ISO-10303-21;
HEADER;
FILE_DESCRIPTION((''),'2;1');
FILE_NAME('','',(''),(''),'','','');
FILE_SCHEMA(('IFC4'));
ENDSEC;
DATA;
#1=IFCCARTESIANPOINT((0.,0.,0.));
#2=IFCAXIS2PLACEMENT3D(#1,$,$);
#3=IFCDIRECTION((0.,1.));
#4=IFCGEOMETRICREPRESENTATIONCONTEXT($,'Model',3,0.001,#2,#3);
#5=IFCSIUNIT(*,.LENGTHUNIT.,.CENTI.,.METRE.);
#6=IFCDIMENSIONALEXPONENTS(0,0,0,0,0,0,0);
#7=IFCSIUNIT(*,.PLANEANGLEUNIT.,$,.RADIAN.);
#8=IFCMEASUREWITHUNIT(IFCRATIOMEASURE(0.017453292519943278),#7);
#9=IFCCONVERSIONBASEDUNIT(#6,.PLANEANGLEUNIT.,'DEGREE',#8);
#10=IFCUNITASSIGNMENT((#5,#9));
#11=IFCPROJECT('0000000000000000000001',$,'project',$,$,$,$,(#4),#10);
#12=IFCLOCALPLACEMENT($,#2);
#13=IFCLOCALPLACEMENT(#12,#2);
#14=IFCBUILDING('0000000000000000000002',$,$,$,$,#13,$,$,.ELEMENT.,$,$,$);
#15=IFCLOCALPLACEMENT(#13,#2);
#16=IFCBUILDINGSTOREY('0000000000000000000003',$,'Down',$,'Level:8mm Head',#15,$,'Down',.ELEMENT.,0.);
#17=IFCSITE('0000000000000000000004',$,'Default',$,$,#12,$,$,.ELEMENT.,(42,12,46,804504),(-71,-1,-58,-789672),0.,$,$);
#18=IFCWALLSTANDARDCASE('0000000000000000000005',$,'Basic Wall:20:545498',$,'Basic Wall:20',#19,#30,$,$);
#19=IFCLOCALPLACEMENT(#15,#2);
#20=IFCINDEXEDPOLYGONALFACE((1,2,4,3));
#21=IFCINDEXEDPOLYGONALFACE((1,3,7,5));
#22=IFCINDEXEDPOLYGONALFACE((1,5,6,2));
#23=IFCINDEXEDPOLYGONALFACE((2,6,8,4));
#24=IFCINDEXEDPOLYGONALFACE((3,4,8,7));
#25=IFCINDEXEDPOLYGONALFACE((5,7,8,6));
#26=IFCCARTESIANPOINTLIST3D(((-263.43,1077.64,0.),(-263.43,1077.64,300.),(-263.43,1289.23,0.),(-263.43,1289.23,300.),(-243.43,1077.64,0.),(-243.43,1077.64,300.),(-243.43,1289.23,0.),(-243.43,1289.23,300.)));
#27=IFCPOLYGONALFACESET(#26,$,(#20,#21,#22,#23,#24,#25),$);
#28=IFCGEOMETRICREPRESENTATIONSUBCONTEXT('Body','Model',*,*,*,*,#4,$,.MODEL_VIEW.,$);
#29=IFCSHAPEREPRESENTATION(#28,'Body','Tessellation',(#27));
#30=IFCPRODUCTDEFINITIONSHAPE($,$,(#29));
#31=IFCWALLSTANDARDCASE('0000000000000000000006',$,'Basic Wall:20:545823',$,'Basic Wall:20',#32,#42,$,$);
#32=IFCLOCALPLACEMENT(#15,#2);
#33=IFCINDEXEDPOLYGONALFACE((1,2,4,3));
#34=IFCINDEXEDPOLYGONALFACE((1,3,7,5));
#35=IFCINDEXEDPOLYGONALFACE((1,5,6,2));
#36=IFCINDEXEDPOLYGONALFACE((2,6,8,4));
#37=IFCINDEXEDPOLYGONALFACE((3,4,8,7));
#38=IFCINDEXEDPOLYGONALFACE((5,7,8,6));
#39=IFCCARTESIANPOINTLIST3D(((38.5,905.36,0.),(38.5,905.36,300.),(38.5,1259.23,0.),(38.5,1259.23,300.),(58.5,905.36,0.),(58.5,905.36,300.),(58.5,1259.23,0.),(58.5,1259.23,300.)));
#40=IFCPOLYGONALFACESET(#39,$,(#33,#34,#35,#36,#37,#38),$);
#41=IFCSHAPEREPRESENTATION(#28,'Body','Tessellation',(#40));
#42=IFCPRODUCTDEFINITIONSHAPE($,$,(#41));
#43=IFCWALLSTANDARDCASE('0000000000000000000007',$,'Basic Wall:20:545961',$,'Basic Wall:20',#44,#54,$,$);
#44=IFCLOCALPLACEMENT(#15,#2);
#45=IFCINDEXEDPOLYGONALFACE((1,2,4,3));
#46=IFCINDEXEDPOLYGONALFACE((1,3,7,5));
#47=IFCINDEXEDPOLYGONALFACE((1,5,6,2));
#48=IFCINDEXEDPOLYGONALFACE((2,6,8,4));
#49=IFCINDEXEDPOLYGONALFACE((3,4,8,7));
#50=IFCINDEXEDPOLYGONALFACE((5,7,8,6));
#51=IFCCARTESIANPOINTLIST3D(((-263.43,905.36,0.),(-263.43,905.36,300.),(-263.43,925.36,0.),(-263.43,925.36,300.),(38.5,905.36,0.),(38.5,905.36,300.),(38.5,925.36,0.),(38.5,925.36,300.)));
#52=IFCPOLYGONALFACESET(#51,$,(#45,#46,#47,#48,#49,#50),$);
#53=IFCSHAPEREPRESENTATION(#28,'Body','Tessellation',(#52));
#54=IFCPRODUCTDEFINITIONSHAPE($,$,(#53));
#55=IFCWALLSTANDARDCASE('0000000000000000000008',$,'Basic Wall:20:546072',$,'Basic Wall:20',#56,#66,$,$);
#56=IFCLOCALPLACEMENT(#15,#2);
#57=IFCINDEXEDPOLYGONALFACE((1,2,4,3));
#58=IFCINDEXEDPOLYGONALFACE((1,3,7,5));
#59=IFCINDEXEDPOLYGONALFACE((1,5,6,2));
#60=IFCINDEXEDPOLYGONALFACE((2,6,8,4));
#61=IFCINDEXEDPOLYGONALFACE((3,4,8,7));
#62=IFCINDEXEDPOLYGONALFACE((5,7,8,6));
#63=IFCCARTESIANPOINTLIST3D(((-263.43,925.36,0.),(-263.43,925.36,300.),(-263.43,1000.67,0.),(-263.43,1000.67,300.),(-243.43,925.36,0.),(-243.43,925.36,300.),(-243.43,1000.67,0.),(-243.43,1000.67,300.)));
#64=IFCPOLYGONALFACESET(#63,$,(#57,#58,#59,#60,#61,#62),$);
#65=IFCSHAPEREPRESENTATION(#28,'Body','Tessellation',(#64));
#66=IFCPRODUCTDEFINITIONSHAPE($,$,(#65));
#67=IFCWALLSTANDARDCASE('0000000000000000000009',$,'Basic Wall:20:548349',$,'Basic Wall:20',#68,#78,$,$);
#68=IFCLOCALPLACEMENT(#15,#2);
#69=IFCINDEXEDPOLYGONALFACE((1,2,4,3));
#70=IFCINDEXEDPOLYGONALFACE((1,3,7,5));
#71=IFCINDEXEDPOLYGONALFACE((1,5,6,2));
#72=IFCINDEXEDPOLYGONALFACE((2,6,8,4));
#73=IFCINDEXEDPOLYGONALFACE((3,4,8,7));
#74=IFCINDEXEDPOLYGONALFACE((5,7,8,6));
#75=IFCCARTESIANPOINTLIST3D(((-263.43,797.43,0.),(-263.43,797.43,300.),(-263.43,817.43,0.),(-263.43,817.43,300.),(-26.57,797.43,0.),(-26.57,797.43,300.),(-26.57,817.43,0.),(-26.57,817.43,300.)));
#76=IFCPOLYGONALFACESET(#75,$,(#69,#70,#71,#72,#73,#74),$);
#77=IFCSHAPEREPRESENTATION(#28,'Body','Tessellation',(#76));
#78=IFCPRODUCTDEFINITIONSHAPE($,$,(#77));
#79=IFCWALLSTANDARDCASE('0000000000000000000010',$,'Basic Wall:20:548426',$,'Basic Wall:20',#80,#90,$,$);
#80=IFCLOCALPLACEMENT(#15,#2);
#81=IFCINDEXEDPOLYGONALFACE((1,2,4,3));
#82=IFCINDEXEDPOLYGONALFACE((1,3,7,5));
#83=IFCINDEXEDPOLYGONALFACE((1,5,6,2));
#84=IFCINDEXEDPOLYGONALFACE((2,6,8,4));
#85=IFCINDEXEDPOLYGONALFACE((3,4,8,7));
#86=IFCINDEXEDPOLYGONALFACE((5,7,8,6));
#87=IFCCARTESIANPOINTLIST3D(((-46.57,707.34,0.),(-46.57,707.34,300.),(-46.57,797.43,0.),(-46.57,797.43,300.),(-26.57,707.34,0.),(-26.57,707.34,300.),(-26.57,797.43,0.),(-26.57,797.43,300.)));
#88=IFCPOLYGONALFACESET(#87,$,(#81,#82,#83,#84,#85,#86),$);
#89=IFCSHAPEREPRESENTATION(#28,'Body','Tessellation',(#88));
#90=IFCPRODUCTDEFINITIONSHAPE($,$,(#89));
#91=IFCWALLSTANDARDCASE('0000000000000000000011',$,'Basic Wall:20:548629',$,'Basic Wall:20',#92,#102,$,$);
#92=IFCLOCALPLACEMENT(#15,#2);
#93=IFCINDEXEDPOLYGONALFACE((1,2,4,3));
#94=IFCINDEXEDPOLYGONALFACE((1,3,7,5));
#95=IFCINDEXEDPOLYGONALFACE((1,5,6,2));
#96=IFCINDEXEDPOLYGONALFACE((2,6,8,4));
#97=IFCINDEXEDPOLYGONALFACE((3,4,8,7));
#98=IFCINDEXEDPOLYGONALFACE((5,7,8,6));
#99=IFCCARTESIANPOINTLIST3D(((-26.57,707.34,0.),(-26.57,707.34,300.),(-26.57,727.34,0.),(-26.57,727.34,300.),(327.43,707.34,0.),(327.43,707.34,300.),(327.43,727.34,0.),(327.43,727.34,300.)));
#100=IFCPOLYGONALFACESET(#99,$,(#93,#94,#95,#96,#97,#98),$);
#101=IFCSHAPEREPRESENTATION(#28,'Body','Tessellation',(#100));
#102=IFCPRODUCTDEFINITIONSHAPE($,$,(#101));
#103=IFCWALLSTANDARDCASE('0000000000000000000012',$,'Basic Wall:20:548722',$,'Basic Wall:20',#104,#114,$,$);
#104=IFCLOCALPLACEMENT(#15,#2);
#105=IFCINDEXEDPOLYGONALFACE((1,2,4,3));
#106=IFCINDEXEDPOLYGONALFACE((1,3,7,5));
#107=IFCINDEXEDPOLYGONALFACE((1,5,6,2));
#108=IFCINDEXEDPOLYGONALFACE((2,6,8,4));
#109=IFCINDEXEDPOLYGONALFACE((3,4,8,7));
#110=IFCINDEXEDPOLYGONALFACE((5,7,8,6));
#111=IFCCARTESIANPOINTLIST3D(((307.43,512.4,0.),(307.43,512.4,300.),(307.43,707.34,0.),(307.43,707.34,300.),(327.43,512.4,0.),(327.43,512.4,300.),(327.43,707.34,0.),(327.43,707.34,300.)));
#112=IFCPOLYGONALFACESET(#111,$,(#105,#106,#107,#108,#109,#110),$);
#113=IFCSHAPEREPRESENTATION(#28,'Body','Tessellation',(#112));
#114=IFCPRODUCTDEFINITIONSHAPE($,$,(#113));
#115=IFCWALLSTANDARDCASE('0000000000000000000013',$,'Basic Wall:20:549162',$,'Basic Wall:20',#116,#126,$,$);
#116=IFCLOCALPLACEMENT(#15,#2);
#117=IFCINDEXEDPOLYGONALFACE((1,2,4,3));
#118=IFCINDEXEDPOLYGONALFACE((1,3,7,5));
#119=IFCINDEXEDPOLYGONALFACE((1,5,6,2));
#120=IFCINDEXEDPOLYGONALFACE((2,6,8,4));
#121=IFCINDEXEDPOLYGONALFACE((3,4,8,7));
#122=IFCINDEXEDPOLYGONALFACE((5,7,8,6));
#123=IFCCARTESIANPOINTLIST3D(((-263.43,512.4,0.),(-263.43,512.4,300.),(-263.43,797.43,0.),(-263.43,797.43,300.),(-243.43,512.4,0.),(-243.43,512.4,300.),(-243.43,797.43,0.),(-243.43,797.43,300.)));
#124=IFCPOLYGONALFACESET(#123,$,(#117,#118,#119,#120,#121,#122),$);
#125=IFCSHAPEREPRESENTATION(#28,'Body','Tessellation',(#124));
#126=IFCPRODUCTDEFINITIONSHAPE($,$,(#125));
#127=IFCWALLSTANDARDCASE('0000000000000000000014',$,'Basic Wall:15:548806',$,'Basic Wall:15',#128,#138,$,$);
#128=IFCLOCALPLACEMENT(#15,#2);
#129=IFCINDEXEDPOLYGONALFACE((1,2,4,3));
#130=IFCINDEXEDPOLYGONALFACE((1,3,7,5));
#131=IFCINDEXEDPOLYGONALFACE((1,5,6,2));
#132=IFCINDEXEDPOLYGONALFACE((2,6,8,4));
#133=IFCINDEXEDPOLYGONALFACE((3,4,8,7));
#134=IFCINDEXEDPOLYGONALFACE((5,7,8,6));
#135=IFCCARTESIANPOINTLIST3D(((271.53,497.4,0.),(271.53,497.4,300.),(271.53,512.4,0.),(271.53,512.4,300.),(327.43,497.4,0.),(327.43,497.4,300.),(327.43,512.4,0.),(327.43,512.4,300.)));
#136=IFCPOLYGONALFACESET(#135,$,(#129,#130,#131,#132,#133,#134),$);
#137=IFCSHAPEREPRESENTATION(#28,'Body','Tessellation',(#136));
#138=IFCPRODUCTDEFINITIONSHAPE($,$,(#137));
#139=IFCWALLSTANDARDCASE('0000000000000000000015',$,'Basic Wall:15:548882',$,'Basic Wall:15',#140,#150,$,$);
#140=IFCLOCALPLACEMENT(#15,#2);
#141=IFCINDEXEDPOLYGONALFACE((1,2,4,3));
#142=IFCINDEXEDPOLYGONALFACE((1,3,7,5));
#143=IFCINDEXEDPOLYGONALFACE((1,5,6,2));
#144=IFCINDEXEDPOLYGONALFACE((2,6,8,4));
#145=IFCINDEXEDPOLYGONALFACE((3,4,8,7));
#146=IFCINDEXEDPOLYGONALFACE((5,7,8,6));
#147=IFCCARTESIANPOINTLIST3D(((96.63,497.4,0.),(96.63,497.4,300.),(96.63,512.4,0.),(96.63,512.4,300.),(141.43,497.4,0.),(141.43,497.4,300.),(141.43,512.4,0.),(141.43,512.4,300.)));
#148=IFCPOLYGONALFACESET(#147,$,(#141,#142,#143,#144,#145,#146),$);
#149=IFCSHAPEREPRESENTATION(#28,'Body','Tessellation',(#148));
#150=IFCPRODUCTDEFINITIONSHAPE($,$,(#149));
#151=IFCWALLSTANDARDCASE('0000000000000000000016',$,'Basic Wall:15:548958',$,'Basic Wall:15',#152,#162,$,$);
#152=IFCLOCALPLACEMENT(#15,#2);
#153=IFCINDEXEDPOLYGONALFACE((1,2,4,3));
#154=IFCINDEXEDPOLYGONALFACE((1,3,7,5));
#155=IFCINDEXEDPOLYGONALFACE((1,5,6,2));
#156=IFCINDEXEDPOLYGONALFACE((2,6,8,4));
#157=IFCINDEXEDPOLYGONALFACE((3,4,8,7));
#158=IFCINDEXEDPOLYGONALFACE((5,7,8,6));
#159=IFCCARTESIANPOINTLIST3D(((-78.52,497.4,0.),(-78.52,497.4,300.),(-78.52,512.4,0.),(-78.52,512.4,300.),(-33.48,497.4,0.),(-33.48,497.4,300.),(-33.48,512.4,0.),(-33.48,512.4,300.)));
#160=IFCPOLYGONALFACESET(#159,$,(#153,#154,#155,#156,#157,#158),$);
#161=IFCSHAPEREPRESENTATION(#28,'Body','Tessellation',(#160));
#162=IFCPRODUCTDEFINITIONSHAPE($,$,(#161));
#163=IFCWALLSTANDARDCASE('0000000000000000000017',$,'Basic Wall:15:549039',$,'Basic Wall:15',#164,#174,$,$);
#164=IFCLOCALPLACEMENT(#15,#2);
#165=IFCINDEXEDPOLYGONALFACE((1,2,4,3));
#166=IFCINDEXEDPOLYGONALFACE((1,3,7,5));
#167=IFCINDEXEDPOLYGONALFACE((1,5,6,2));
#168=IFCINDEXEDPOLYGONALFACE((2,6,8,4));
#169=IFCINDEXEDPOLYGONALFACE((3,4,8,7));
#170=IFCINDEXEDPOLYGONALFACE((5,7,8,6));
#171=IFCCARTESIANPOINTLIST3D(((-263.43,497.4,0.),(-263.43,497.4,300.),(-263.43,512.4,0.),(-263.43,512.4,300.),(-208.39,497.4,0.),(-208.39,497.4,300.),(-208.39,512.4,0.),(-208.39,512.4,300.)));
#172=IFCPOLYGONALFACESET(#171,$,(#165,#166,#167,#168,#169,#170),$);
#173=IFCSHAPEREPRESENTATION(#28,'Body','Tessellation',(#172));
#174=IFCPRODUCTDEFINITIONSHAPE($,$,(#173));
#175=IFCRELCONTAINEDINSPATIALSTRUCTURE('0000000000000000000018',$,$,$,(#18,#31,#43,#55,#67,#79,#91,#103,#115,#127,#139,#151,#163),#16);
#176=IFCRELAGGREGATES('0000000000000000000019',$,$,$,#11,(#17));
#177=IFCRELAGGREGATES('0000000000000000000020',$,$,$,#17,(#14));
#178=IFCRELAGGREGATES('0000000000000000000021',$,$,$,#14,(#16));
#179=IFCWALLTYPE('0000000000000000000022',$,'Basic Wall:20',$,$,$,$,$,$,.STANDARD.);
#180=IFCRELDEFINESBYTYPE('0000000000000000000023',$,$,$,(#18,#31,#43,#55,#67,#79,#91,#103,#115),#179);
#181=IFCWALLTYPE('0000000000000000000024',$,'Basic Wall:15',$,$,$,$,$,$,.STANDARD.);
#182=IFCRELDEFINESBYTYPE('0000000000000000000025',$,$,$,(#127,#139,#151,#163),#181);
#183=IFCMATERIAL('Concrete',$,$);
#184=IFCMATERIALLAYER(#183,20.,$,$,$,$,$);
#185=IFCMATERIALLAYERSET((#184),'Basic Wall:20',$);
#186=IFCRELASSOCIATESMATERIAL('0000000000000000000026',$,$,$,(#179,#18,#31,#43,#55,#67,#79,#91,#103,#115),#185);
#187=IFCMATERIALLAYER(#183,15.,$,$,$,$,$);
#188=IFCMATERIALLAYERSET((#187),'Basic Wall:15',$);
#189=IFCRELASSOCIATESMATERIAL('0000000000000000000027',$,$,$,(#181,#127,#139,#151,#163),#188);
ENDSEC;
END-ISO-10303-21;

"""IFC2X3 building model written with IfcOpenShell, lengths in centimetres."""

from ifc_helpers import new_model, entity, si_unit, converted_unit, direction, frame, frame_2d, origin, place, context, subcontext, project, spatial, rectangle, extrude, material, layer, layer_set, layer_usage, type_object, element, save


model = new_model("IFC2X3")

# Units and contexts
model_context = context("Model", 3, precision=0.001, world=origin(), true_north=direction((0.0, 1.0)))
body_context = subcontext(model_context, "Body", "Model", "MODEL_VIEW")
ifc_project = project(units=[si_unit("LENGTHUNIT", "METRE", prefix="CENTI"), converted_unit("PLANEANGLEUNIT", "DEGREE", entity("IfcRatioMeasure", 0.017453292519943278), si_unit("PLANEANGLEUNIT", "RADIAN"), dimensions=[0, 0, 0, 0, 0, 0, 0])], contexts=[model_context])

# Site, building, storey
site_placement = place(None, origin())
site = spatial("IfcSite", under=ifc_project, at=site_placement, Name="Default", CompositionType="ELEMENT", RefLatitude=(42, 12, 46, 804504), RefLongitude=(-71, -1, -58, -789672), RefElevation=0.0)
building_placement = place(site_placement, origin())
building = spatial("IfcBuilding", under=site, at=building_placement, CompositionType="ELEMENT")
storey_placement = place(building_placement, origin())
storey = spatial("IfcBuildingStorey", under=building, at=storey_placement, Name="Down", ObjectType="Level:8mm Head", LongName="Down", CompositionType="ELEMENT", Elevation=0.0)

# Walls
ifc_material = material(Name="Concrete")
ifc_layer_1 = layer(ifc_material, 20.0)
ifc_layer_set_1 = layer_set([ifc_layer_1], Name="Basic Wall:20")
wall_type_1 = type_object("IfcWallType", Name="Basic Wall:20", PredefinedType="STANDARD", material=ifc_layer_set_1)
ifc_layer_usage_1 = layer_usage(ifc_layer_set_1, "AXIS2", "NEGATIVE", 10.0)
wall_1_placement = place(storey_placement, frame((-253.43, 1077.64, 0.0), z_axis=(0.0, 0.0, 1.0), x_axis=(0.0, 1.0, 0.0)))
element("IfcWallStandardCase", 1, at=wall_1_placement, inside=storey, type_object=wall_type_1, material=ifc_layer_usage_1, Name="Basic Wall:20:545498", ObjectType="Basic Wall:20", context=body_context, shape_type="SweptSolid", body=[
    extrude(rectangle(XDim=211.59, YDim=20.0, at=frame_2d((105.79, 0.0), x_axis=(-1.0, 0.0))), origin(), (0.0, 0.0, 1.0), 300.0),
])
ifc_layer_usage_2 = layer_usage(ifc_layer_set_1, "AXIS2", "NEGATIVE", 10.0)
wall_2_placement = place(storey_placement, frame((48.5, 1259.23, 0.0), z_axis=(0.0, 0.0, 1.0), x_axis=(0.0, -1.0, 0.0)))
element("IfcWallStandardCase", 2, at=wall_2_placement, inside=storey, type_object=wall_type_1, material=ifc_layer_usage_2, Name="Basic Wall:20:545823", ObjectType="Basic Wall:20", context=body_context, shape_type="SweptSolid", body=[
    extrude(rectangle(XDim=353.87, YDim=20.0, at=frame_2d((176.94, 0.0), x_axis=(-1.0, 0.0))), origin(), (0.0, 0.0, 1.0), 300.0),
])
ifc_layer_usage_3 = layer_usage(ifc_layer_set_1, "AXIS2", "NEGATIVE", 10.0)
wall_3_placement = place(storey_placement, frame((38.5, 915.36, 0.0), z_axis=(0.0, 0.0, 1.0), x_axis=(-1.0, 0.0, 0.0)))
element("IfcWallStandardCase", 3, at=wall_3_placement, inside=storey, type_object=wall_type_1, material=ifc_layer_usage_3, Name="Basic Wall:20:545961", ObjectType="Basic Wall:20", context=body_context, shape_type="SweptSolid", body=[
    extrude(rectangle(XDim=301.93, YDim=20.0, at=frame_2d((150.97, 0.0), x_axis=(-1.0, 0.0))), origin(), (0.0, 0.0, 1.0), 300.0),
])
ifc_layer_usage_4 = layer_usage(ifc_layer_set_1, "AXIS2", "NEGATIVE", 10.0)
wall_4_placement = place(storey_placement, frame((-253.43, 925.36, 0.0), z_axis=(0.0, 0.0, 1.0), x_axis=(0.0, 1.0, 0.0)))
element("IfcWallStandardCase", 4, at=wall_4_placement, inside=storey, type_object=wall_type_1, material=ifc_layer_usage_4, Name="Basic Wall:20:546072", ObjectType="Basic Wall:20", context=body_context, shape_type="SweptSolid", body=[
    extrude(rectangle(XDim=75.32, YDim=20.0, at=frame_2d((37.66, 0.0), x_axis=(-1.0, 0.0))), origin(), (0.0, 0.0, 1.0), 300.0),
])
ifc_layer_usage_5 = layer_usage(ifc_layer_set_1, "AXIS2", "NEGATIVE", 10.0)
wall_5_placement = place(storey_placement, frame((-263.43, 807.43, 0.0)))
element("IfcWallStandardCase", 5, at=wall_5_placement, inside=storey, type_object=wall_type_1, material=ifc_layer_usage_5, Name="Basic Wall:20:548349", ObjectType="Basic Wall:20", context=body_context, shape_type="SweptSolid", body=[
    extrude(rectangle(XDim=236.86, YDim=20.0, at=frame_2d((118.43, 0.0), x_axis=(-1.0, 0.0))), origin(), (0.0, 0.0, 1.0), 300.0),
])
ifc_layer_usage_6 = layer_usage(ifc_layer_set_1, "AXIS2", "NEGATIVE", 10.0)
wall_6_placement = place(storey_placement, frame((-36.57, 797.43, 0.0), z_axis=(0.0, 0.0, 1.0), x_axis=(0.0, -1.0, 0.0)))
element("IfcWallStandardCase", 6, at=wall_6_placement, inside=storey, type_object=wall_type_1, material=ifc_layer_usage_6, Name="Basic Wall:20:548426", ObjectType="Basic Wall:20", context=body_context, shape_type="SweptSolid", body=[
    extrude(rectangle(XDim=90.09, YDim=20.0, at=frame_2d((45.05, 0.0), x_axis=(-1.0, 0.0))), origin(), (0.0, 0.0, 1.0), 300.0),
])
ifc_layer_usage_7 = layer_usage(ifc_layer_set_1, "AXIS2", "POSITIVE", -10.0)
wall_7_placement = place(storey_placement, frame((-26.57, 717.34, 0.0)))
element("IfcWallStandardCase", 7, at=wall_7_placement, inside=storey, type_object=wall_type_1, material=ifc_layer_usage_7, Name="Basic Wall:20:548629", ObjectType="Basic Wall:20", context=body_context, shape_type="SweptSolid", body=[
    extrude(rectangle(XDim=354.0, YDim=20.0, at=frame_2d((177.0, 0.0), x_axis=(-1.0, 0.0))), origin(), (0.0, 0.0, 1.0), 300.0),
])
ifc_layer_usage_8 = layer_usage(ifc_layer_set_1, "AXIS2", "NEGATIVE", 10.0)
wall_8_placement = place(storey_placement, frame((317.43, 707.34, 0.0), z_axis=(0.0, 0.0, 1.0), x_axis=(0.0, -1.0, 0.0)))
element("IfcWallStandardCase", 8, at=wall_8_placement, inside=storey, type_object=wall_type_1, material=ifc_layer_usage_8, Name="Basic Wall:20:548722", ObjectType="Basic Wall:20", context=body_context, shape_type="SweptSolid", body=[
    extrude(rectangle(XDim=194.94, YDim=20.0, at=frame_2d((97.47, 0.0), x_axis=(-1.0, 0.0))), origin(), (0.0, 0.0, 1.0), 300.0),
])
ifc_layer_usage_9 = layer_usage(ifc_layer_set_1, "AXIS2", "NEGATIVE", 10.0)
wall_9_placement = place(storey_placement, frame((-253.43, 512.4, 0.0), z_axis=(0.0, 0.0, 1.0), x_axis=(0.0, 1.0, 0.0)))
element("IfcWallStandardCase", 9, at=wall_9_placement, inside=storey, type_object=wall_type_1, material=ifc_layer_usage_9, Name="Basic Wall:20:549162", ObjectType="Basic Wall:20", context=body_context, shape_type="SweptSolid", body=[
    extrude(rectangle(XDim=285.03, YDim=20.0, at=frame_2d((142.51, 0.0), x_axis=(-1.0, 0.0))), origin(), (0.0, 0.0, 1.0), 300.0),
])
ifc_layer_2 = layer(ifc_material, 15.0)
ifc_layer_set_2 = layer_set([ifc_layer_2], Name="Basic Wall:15")
ifc_layer_usage_10 = layer_usage(ifc_layer_set_2, "AXIS2", "NEGATIVE", 7.5)
wall_type_2 = type_object("IfcWallType", Name="Basic Wall:15", PredefinedType="STANDARD", material=ifc_layer_set_2)
wall_10_placement = place(storey_placement, frame((327.43, 504.9, 0.0), z_axis=(0.0, 0.0, 1.0), x_axis=(-1.0, 0.0, 0.0)))
element("IfcWallStandardCase", 10, at=wall_10_placement, inside=storey, type_object=wall_type_2, material=ifc_layer_usage_10, Name="Basic Wall:15:548806", ObjectType="Basic Wall:15", context=body_context, shape_type="SweptSolid", body=[
    extrude(rectangle(XDim=55.9, YDim=15.0, at=frame_2d((27.95, 0.0), x_axis=(-1.0, 0.0))), origin(), (0.0, 0.0, 1.0), 300.0),
])
ifc_layer_usage_11 = layer_usage(ifc_layer_set_2, "AXIS2", "NEGATIVE", 7.5)
wall_11_placement = place(storey_placement, frame((141.43, 504.9, 0.0), z_axis=(0.0, 0.0, 1.0), x_axis=(-1.0, 0.0, 0.0)))
element("IfcWallStandardCase", 11, at=wall_11_placement, inside=storey, type_object=wall_type_2, material=ifc_layer_usage_11, Name="Basic Wall:15:548882", ObjectType="Basic Wall:15", context=body_context, shape_type="SweptSolid", body=[
    extrude(rectangle(XDim=44.8, YDim=15.0, at=frame_2d((22.4, 0.0), x_axis=(-1.0, 0.0))), origin(), (0.0, 0.0, 1.0), 300.0),
])
ifc_layer_usage_12 = layer_usage(ifc_layer_set_2, "AXIS2", "NEGATIVE", 7.5)
wall_12_placement = place(storey_placement, frame((-33.48, 504.9, 0.0), z_axis=(0.0, 0.0, 1.0), x_axis=(-1.0, 0.0, 0.0)))
element("IfcWallStandardCase", 12, at=wall_12_placement, inside=storey, type_object=wall_type_2, material=ifc_layer_usage_12, Name="Basic Wall:15:548958", ObjectType="Basic Wall:15", context=body_context, shape_type="SweptSolid", body=[
    extrude(rectangle(XDim=45.04, YDim=15.0, at=frame_2d((22.52, 0.0), x_axis=(-1.0, 0.0))), origin(), (0.0, 0.0, 1.0), 300.0),
])
ifc_layer_usage_13 = layer_usage(ifc_layer_set_2, "AXIS2", "NEGATIVE", 7.5)
wall_13_placement = place(storey_placement, frame((-208.39, 504.9, 0.0), z_axis=(0.0, 0.0, 1.0), x_axis=(-1.0, 0.0, 0.0)))
element("IfcWallStandardCase", 13, at=wall_13_placement, inside=storey, type_object=wall_type_2, material=ifc_layer_usage_13, Name="Basic Wall:15:549039", ObjectType="Basic Wall:15", context=body_context, shape_type="SweptSolid", body=[
    extrude(rectangle(XDim=55.05, YDim=15.0, at=frame_2d((27.52, 0.0), x_axis=(-1.0, 0.0))), origin(), (0.0, 0.0, 1.0), 300.0),
])

save(model, "model.ifc")
